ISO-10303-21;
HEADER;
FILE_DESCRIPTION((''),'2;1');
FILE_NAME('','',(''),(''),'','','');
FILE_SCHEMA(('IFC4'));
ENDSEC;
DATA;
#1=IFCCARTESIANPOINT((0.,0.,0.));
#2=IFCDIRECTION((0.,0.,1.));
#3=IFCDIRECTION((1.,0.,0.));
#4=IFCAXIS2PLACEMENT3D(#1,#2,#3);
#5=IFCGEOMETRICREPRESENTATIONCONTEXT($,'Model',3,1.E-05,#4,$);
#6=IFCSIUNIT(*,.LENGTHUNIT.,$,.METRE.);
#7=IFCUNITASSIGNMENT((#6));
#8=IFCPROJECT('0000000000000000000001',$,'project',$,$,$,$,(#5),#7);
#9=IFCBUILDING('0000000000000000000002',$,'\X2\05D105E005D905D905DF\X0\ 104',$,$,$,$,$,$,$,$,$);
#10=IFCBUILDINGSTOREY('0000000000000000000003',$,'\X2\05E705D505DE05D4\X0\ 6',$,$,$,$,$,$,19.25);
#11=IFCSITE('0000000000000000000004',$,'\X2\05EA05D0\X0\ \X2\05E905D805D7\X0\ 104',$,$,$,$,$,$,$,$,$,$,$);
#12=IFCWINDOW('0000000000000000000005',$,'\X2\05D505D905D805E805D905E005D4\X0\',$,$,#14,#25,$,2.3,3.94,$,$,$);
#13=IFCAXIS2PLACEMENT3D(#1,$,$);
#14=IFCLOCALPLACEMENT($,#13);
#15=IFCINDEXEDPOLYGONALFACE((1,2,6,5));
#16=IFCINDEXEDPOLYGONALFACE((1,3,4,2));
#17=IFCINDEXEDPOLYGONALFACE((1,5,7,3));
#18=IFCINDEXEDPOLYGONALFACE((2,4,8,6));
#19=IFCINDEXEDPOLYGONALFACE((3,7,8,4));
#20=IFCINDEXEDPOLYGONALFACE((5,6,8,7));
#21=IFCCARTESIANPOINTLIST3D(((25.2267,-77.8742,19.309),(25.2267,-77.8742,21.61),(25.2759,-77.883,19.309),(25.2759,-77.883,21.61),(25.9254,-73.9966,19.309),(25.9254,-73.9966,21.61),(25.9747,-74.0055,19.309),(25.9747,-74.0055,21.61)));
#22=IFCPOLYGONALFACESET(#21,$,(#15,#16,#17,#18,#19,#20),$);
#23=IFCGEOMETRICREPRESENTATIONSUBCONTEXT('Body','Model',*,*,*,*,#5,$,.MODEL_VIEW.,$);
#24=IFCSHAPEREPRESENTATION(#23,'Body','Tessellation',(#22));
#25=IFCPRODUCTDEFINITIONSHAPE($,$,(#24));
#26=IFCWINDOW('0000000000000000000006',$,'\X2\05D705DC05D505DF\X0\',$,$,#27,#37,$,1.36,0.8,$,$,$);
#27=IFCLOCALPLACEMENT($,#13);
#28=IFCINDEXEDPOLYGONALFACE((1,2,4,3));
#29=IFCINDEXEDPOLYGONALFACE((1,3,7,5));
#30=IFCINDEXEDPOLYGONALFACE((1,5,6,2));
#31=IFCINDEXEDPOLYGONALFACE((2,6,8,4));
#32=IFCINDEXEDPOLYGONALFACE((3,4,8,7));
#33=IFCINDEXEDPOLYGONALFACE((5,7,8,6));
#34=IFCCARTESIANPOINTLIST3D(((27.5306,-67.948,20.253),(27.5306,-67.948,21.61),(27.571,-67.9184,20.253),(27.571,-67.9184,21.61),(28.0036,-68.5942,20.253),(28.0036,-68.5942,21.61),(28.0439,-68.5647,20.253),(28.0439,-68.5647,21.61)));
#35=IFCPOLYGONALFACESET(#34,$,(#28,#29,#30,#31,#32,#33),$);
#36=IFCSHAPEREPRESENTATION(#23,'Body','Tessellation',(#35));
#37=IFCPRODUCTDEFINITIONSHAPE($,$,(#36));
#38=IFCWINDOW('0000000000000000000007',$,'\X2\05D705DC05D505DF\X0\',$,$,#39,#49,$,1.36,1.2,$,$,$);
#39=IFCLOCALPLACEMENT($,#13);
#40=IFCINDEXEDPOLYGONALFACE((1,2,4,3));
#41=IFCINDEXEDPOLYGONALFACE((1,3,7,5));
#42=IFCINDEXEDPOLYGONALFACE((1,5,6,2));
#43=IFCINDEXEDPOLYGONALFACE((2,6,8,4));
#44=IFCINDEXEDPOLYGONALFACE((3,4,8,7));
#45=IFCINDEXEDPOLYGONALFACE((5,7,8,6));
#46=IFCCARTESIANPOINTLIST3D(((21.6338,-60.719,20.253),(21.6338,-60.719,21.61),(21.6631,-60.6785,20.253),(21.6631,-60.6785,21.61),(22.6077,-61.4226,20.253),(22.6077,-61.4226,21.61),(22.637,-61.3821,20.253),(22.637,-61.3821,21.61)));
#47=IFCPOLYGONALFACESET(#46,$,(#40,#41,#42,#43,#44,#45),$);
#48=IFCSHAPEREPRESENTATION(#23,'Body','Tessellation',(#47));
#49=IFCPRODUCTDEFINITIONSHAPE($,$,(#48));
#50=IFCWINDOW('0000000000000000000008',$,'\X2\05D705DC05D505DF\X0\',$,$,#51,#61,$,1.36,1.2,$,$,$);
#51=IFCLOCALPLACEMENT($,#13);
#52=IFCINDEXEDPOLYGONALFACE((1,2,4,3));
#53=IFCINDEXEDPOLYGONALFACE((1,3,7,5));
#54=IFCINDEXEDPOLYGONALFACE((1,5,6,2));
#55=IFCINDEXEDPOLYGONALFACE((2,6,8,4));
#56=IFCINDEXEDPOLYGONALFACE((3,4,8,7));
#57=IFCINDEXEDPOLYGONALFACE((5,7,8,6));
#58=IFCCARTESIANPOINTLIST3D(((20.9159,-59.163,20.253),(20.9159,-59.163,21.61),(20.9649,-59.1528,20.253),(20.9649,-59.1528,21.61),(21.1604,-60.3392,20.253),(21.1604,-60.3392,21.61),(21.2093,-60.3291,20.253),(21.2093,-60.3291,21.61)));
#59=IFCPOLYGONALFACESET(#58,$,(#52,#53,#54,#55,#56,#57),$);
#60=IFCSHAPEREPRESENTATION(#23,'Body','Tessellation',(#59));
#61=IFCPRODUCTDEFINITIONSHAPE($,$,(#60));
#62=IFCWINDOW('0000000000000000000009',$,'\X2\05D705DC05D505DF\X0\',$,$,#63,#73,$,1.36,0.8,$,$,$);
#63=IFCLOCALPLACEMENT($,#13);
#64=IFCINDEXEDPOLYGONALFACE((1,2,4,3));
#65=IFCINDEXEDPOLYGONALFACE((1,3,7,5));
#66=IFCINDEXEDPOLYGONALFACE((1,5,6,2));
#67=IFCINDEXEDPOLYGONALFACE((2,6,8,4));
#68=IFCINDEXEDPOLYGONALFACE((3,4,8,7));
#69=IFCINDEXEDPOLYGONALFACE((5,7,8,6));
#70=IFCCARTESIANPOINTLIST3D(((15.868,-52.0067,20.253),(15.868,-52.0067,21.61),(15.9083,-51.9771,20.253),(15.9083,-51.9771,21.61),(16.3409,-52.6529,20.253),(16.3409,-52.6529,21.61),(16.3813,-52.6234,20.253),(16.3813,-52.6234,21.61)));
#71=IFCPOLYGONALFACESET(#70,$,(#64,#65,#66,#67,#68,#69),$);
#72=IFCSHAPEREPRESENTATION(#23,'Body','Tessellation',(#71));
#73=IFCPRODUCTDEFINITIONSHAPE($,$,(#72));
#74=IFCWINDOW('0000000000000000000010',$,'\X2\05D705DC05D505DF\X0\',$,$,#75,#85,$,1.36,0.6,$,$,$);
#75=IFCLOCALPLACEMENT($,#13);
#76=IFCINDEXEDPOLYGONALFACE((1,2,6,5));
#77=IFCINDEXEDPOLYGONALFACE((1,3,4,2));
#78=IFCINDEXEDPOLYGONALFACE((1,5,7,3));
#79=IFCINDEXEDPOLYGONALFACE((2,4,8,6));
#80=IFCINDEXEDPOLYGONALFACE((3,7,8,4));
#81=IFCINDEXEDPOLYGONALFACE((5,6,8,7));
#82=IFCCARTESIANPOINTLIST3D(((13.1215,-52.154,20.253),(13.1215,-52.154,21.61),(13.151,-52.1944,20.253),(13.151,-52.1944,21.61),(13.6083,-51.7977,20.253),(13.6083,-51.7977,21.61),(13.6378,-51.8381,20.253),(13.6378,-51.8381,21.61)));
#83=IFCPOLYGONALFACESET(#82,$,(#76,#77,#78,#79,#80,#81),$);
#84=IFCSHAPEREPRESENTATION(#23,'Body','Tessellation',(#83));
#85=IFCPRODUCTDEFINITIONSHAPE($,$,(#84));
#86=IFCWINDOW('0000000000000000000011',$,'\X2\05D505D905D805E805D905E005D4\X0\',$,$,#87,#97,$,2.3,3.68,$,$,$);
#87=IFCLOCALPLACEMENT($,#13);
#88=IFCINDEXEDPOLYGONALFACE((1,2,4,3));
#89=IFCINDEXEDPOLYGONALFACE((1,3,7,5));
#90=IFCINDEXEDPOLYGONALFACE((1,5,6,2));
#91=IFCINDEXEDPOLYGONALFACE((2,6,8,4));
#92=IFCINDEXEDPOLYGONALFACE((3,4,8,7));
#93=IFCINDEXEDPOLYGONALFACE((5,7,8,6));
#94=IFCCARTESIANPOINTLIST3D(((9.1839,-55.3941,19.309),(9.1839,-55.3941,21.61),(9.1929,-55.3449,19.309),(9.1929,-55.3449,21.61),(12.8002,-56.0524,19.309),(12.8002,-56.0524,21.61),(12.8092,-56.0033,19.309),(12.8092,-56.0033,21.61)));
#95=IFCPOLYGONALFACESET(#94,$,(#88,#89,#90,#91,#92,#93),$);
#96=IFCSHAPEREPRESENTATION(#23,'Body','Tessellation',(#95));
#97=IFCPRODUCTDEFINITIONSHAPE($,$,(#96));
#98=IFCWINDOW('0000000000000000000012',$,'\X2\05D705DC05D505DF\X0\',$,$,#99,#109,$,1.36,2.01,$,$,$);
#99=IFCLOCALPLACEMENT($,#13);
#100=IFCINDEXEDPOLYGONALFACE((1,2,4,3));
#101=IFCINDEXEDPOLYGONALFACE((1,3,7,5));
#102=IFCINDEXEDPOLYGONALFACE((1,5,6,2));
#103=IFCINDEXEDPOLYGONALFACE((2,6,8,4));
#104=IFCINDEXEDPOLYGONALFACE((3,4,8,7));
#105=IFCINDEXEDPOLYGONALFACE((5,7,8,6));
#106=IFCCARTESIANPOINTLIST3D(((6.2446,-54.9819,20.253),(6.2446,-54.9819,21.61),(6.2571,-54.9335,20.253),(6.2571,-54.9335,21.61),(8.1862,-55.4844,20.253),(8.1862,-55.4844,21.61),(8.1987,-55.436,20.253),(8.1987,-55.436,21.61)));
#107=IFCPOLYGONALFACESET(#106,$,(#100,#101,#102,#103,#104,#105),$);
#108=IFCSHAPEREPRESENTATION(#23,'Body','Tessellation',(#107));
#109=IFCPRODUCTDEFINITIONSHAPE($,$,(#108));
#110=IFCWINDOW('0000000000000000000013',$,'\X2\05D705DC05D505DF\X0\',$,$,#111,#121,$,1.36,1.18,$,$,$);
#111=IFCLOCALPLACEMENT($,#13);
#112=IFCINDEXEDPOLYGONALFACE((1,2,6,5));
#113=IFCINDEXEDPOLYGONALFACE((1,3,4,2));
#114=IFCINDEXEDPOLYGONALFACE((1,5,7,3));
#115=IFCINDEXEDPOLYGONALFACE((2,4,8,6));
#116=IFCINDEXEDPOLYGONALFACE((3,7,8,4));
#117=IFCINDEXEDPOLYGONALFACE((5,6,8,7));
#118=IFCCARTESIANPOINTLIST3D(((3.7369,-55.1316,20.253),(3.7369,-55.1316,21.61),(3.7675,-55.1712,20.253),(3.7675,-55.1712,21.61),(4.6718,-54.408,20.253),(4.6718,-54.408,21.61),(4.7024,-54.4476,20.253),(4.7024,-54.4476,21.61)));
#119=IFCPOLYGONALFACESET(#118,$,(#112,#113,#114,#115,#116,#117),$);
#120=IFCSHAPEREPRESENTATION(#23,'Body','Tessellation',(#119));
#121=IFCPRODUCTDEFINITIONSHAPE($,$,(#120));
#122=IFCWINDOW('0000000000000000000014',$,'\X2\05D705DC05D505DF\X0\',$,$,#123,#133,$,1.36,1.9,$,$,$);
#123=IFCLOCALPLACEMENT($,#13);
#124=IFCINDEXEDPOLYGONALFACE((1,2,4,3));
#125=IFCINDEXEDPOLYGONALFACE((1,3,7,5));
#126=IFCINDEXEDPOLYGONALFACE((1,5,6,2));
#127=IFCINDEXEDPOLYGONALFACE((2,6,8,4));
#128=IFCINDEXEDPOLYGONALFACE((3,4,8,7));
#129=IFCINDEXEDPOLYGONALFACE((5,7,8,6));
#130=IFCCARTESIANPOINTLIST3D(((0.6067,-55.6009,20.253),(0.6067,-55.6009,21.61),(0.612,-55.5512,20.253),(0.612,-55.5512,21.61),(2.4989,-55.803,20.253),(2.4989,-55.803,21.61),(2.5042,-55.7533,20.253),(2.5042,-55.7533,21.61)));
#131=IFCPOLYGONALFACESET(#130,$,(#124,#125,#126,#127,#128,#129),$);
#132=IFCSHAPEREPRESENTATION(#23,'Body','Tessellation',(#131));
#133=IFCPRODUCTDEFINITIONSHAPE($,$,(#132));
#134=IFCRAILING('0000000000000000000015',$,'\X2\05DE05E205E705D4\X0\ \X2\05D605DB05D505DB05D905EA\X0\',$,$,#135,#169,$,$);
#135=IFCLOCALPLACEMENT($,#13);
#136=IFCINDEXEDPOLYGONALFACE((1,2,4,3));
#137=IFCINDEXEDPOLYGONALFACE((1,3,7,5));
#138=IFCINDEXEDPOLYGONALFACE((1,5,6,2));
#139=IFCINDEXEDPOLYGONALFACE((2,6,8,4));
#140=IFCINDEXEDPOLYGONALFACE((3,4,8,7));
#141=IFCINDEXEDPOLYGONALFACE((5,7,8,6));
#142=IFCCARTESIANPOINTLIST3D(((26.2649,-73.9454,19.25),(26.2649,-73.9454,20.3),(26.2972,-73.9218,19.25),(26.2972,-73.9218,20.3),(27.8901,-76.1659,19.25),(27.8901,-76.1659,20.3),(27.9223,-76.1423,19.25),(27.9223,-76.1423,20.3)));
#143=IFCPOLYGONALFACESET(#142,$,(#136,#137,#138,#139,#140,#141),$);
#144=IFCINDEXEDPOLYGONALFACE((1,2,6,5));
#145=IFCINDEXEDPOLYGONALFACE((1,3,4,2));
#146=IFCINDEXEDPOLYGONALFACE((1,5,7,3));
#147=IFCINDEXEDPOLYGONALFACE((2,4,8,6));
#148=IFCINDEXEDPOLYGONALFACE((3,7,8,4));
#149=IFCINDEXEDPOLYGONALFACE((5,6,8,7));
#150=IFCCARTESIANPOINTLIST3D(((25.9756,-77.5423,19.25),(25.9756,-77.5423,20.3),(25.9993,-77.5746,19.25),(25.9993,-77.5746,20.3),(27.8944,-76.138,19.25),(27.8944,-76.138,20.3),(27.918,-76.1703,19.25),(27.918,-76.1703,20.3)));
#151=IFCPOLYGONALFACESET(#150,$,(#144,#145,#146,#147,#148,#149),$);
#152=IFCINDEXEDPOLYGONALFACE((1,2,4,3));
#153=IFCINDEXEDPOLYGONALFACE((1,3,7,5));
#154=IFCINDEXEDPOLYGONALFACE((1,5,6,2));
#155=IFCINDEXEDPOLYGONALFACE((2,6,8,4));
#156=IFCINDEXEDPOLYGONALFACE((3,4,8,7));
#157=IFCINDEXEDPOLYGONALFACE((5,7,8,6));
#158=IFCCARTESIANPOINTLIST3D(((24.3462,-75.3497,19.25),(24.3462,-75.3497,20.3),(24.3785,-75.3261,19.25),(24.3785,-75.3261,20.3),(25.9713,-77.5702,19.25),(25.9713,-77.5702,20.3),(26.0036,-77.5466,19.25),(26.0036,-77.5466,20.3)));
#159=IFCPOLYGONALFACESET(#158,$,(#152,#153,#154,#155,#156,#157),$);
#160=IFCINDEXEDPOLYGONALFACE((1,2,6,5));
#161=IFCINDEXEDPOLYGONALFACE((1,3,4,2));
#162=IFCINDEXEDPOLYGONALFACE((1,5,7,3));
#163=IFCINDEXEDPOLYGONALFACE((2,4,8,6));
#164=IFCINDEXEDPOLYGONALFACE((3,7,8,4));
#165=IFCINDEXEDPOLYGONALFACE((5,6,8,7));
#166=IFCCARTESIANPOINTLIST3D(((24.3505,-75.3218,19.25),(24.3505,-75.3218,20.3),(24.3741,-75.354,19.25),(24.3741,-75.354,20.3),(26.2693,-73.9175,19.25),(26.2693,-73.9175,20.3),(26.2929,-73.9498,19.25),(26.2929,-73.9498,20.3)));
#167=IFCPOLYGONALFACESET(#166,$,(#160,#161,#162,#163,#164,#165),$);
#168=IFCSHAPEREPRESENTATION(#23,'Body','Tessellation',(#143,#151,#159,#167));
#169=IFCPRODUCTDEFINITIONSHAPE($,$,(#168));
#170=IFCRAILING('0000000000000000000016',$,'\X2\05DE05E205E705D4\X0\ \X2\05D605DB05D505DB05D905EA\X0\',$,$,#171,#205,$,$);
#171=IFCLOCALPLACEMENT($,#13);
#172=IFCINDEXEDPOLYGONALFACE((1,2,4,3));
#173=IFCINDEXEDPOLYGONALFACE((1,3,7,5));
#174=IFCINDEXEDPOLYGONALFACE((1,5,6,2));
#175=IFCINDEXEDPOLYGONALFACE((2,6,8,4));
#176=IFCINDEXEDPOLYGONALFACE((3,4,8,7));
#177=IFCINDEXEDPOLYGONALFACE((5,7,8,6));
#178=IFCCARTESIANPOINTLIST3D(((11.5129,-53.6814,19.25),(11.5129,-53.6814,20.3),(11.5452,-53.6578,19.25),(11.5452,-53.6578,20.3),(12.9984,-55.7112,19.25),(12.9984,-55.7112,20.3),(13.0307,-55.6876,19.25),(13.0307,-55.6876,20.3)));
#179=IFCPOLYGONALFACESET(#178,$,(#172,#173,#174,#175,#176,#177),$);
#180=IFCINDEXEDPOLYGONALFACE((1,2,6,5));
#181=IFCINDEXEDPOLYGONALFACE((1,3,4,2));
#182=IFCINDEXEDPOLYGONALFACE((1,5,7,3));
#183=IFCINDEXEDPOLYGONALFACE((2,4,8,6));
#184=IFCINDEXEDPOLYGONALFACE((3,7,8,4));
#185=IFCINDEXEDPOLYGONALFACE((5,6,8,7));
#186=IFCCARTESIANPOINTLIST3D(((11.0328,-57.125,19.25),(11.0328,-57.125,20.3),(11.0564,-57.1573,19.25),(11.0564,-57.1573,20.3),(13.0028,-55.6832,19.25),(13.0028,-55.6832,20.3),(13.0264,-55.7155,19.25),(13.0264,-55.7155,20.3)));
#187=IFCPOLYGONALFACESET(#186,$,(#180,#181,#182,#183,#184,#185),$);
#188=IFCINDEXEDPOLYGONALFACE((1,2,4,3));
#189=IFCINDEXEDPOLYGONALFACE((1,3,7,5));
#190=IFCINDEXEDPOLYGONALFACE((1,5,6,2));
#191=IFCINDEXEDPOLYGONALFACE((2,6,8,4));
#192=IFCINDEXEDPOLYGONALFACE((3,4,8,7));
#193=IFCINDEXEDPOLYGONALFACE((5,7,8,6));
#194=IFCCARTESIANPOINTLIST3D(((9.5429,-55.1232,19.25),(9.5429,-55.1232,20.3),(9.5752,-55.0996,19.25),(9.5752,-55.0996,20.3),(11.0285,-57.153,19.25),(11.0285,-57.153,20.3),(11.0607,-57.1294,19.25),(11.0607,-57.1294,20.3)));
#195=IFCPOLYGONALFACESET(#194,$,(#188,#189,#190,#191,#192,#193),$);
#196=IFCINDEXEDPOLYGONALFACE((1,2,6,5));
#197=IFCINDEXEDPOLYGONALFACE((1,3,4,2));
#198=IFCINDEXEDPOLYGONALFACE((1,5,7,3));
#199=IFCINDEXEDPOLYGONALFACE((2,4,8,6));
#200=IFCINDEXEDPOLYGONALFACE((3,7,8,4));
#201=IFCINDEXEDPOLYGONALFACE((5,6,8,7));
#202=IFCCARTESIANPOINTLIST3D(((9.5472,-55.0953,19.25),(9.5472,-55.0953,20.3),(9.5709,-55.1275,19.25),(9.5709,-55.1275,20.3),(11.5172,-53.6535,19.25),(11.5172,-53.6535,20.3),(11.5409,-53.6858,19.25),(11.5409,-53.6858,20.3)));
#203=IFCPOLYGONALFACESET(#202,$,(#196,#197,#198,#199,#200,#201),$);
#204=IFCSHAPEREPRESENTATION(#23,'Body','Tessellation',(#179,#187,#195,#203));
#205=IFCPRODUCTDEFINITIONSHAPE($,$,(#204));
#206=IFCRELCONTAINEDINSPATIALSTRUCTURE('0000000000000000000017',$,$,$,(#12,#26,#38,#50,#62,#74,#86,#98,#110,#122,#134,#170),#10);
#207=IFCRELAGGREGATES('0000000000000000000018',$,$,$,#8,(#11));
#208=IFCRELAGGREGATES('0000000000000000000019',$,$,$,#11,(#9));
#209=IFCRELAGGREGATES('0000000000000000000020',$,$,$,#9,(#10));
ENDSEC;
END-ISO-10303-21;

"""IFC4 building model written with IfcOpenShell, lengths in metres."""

from ifc_helpers import new_model, si_unit, frame, origin_with_axes, context, subcontext, project, spatial, polyline, outline, extrude, element, save


model = new_model("IFC4")

# Units and contexts
model_context = context("Model", 3, precision=1e-05, world=origin_with_axes())
body_context = subcontext(model_context, "Body", "Model", "MODEL_VIEW")
ifc_project = project(units=[si_unit("LENGTHUNIT", "METRE")], contexts=[model_context])

# Site, building, storey
site = spatial("IfcSite", under=ifc_project, Name="תא שטח 104")
building = spatial("IfcBuilding", under=site, Name="בניין 104")
storey = spatial("IfcBuildingStorey", under=building, Name="קומה 6", Elevation=19.25)

# Windows
element("IfcWindow", 1, inside=storey, Name="ויטרינה", OverallHeight=2.3, OverallWidth=3.94, context=body_context, shape_type="SweptSolid", body=[
    extrude(outline(polyline([(25.2759, -77.883), (25.9747, -74.0055), (25.9254, -73.9966), (25.2267, -77.8742), (25.2759, -77.883)])), frame((0.0, 0.0, 19.309)), (0.0, 0.0, 1.0), 2.301),
])
element("IfcWindow", 2, inside=storey, Name="חלון", OverallHeight=1.36, OverallWidth=0.8, context=body_context, shape_type="SweptSolid", body=[
    extrude(outline(polyline([(28.0439, -68.5647), (27.571, -67.9184), (27.5306, -67.948), (28.0036, -68.5942), (28.0439, -68.5647)])), frame((0.0, 0.0, 20.253)), (0.0, 0.0, 1.0), 1.357),
])
element("IfcWindow", 3, inside=storey, Name="חלון", OverallHeight=1.36, OverallWidth=1.2, context=body_context, shape_type="SweptSolid", body=[
    extrude(outline(polyline([(22.637, -61.3821), (21.6631, -60.6785), (21.6338, -60.719), (22.6077, -61.4226), (22.637, -61.3821)])), frame((0.0, 0.0, 20.253)), (0.0, 0.0, 1.0), 1.357),
])
element("IfcWindow", 4, inside=storey, Name="חלון", OverallHeight=1.36, OverallWidth=1.2, context=body_context, shape_type="SweptSolid", body=[
    extrude(outline(polyline([(21.2093, -60.3291), (20.9649, -59.1528), (20.9159, -59.163), (21.1604, -60.3392), (21.2093, -60.3291)])), frame((0.0, 0.0, 20.253)), (0.0, 0.0, 1.0), 1.357),
])
element("IfcWindow", 5, inside=storey, Name="חלון", OverallHeight=1.36, OverallWidth=0.8, context=body_context, shape_type="SweptSolid", body=[
    extrude(outline(polyline([(16.3813, -52.6234), (15.9083, -51.9771), (15.868, -52.0067), (16.3409, -52.6529), (16.3813, -52.6234)])), frame((0.0, 0.0, 20.253)), (0.0, 0.0, 1.0), 1.357),
])
element("IfcWindow", 6, inside=storey, Name="חלון", OverallHeight=1.36, OverallWidth=0.6, context=body_context, shape_type="SweptSolid", body=[
    extrude(outline(polyline([(13.6083, -51.7977), (13.1215, -52.154), (13.151, -52.1944), (13.6378, -51.8381), (13.6083, -51.7977)])), frame((0.0, 0.0, 20.253)), (0.0, 0.0, 1.0), 1.357),
])
element("IfcWindow", 7, inside=storey, Name="ויטרינה", OverallHeight=2.3, OverallWidth=3.68, context=body_context, shape_type="SweptSolid", body=[
    extrude(outline(polyline([(12.8092, -56.0033), (9.1929, -55.3449), (9.1839, -55.3941), (12.8002, -56.0524), (12.8092, -56.0033)])), frame((0.0, 0.0, 19.309)), (0.0, 0.0, 1.0), 2.301),
])
element("IfcWindow", 8, inside=storey, Name="חלון", OverallHeight=1.36, OverallWidth=2.01, context=body_context, shape_type="SweptSolid", body=[
    extrude(outline(polyline([(8.1987, -55.436), (6.2571, -54.9335), (6.2446, -54.9819), (8.1862, -55.4844), (8.1987, -55.436)])), frame((0.0, 0.0, 20.253)), (0.0, 0.0, 1.0), 1.357),
])
element("IfcWindow", 9, inside=storey, Name="חלון", OverallHeight=1.36, OverallWidth=1.18, context=body_context, shape_type="SweptSolid", body=[
    extrude(outline(polyline([(4.6718, -54.408), (3.7369, -55.1316), (3.7675, -55.1712), (4.7024, -54.4476), (4.6718, -54.408)])), frame((0.0, 0.0, 20.253)), (0.0, 0.0, 1.0), 1.357),
])
element("IfcWindow", 10, inside=storey, Name="חלון", OverallHeight=1.36, OverallWidth=1.9, context=body_context, shape_type="SweptSolid", body=[
    extrude(outline(polyline([(2.5042, -55.7533), (0.612, -55.5512), (0.6067, -55.6009), (2.4989, -55.803), (2.5042, -55.7533)])), frame((0.0, 0.0, 20.253)), (0.0, 0.0, 1.0), 1.357),
])

# Railings
element("IfcRailing", 11, inside=storey, Name="מעקה זכוכית", context=body_context, shape_type="SweptSolid", body=[
    extrude(outline(polyline([(26.2649, -73.9454), (27.8901, -76.1659), (27.9223, -76.1423), (26.2972, -73.9218), (26.2649, -73.9454)])), frame((0.0, 0.0, 19.25)), (0.0, 0.0, 1.0), 1.05),
    extrude(outline(polyline([(27.8944, -76.138), (25.9756, -77.5423), (25.9993, -77.5746), (27.918, -76.1703), (27.8944, -76.138)])), frame((0.0, 0.0, 19.25)), (0.0, 0.0, 1.0), 1.05),
    extrude(outline(polyline([(26.0036, -77.5466), (24.3785, -75.3261), (24.3462, -75.3497), (25.9713, -77.5702), (26.0036, -77.5466)])), frame((0.0, 0.0, 19.25)), (0.0, 0.0, 1.0), 1.05),
    extrude(outline(polyline([(24.3741, -75.354), (26.2929, -73.9498), (26.2693, -73.9175), (24.3505, -75.3218), (24.3741, -75.354)])), frame((0.0, 0.0, 19.25)), (0.0, 0.0, 1.0), 1.05),
])
element("IfcRailing", 12, inside=storey, Name="מעקה זכוכית", context=body_context, shape_type="SweptSolid", body=[
    extrude(outline(polyline([(11.5129, -53.6814), (12.9984, -55.7112), (13.0307, -55.6876), (11.5452, -53.6578), (11.5129, -53.6814)])), frame((0.0, 0.0, 19.25)), (0.0, 0.0, 1.0), 1.05),
    extrude(outline(polyline([(13.0028, -55.6832), (11.0328, -57.125), (11.0564, -57.1573), (13.0264, -55.7155), (13.0028, -55.6832)])), frame((0.0, 0.0, 19.25)), (0.0, 0.0, 1.0), 1.05),
    extrude(outline(polyline([(11.0607, -57.1294), (9.5752, -55.0996), (9.5429, -55.1232), (11.0285, -57.153), (11.0607, -57.1294)])), frame((0.0, 0.0, 19.25)), (0.0, 0.0, 1.0), 1.05),
    extrude(outline(polyline([(9.5709, -55.1275), (11.5409, -53.6858), (11.5172, -53.6535), (9.5472, -55.0953), (9.5709, -55.1275)])), frame((0.0, 0.0, 19.25)), (0.0, 0.0, 1.0), 1.05),
])

save(model, "model.ifc")
